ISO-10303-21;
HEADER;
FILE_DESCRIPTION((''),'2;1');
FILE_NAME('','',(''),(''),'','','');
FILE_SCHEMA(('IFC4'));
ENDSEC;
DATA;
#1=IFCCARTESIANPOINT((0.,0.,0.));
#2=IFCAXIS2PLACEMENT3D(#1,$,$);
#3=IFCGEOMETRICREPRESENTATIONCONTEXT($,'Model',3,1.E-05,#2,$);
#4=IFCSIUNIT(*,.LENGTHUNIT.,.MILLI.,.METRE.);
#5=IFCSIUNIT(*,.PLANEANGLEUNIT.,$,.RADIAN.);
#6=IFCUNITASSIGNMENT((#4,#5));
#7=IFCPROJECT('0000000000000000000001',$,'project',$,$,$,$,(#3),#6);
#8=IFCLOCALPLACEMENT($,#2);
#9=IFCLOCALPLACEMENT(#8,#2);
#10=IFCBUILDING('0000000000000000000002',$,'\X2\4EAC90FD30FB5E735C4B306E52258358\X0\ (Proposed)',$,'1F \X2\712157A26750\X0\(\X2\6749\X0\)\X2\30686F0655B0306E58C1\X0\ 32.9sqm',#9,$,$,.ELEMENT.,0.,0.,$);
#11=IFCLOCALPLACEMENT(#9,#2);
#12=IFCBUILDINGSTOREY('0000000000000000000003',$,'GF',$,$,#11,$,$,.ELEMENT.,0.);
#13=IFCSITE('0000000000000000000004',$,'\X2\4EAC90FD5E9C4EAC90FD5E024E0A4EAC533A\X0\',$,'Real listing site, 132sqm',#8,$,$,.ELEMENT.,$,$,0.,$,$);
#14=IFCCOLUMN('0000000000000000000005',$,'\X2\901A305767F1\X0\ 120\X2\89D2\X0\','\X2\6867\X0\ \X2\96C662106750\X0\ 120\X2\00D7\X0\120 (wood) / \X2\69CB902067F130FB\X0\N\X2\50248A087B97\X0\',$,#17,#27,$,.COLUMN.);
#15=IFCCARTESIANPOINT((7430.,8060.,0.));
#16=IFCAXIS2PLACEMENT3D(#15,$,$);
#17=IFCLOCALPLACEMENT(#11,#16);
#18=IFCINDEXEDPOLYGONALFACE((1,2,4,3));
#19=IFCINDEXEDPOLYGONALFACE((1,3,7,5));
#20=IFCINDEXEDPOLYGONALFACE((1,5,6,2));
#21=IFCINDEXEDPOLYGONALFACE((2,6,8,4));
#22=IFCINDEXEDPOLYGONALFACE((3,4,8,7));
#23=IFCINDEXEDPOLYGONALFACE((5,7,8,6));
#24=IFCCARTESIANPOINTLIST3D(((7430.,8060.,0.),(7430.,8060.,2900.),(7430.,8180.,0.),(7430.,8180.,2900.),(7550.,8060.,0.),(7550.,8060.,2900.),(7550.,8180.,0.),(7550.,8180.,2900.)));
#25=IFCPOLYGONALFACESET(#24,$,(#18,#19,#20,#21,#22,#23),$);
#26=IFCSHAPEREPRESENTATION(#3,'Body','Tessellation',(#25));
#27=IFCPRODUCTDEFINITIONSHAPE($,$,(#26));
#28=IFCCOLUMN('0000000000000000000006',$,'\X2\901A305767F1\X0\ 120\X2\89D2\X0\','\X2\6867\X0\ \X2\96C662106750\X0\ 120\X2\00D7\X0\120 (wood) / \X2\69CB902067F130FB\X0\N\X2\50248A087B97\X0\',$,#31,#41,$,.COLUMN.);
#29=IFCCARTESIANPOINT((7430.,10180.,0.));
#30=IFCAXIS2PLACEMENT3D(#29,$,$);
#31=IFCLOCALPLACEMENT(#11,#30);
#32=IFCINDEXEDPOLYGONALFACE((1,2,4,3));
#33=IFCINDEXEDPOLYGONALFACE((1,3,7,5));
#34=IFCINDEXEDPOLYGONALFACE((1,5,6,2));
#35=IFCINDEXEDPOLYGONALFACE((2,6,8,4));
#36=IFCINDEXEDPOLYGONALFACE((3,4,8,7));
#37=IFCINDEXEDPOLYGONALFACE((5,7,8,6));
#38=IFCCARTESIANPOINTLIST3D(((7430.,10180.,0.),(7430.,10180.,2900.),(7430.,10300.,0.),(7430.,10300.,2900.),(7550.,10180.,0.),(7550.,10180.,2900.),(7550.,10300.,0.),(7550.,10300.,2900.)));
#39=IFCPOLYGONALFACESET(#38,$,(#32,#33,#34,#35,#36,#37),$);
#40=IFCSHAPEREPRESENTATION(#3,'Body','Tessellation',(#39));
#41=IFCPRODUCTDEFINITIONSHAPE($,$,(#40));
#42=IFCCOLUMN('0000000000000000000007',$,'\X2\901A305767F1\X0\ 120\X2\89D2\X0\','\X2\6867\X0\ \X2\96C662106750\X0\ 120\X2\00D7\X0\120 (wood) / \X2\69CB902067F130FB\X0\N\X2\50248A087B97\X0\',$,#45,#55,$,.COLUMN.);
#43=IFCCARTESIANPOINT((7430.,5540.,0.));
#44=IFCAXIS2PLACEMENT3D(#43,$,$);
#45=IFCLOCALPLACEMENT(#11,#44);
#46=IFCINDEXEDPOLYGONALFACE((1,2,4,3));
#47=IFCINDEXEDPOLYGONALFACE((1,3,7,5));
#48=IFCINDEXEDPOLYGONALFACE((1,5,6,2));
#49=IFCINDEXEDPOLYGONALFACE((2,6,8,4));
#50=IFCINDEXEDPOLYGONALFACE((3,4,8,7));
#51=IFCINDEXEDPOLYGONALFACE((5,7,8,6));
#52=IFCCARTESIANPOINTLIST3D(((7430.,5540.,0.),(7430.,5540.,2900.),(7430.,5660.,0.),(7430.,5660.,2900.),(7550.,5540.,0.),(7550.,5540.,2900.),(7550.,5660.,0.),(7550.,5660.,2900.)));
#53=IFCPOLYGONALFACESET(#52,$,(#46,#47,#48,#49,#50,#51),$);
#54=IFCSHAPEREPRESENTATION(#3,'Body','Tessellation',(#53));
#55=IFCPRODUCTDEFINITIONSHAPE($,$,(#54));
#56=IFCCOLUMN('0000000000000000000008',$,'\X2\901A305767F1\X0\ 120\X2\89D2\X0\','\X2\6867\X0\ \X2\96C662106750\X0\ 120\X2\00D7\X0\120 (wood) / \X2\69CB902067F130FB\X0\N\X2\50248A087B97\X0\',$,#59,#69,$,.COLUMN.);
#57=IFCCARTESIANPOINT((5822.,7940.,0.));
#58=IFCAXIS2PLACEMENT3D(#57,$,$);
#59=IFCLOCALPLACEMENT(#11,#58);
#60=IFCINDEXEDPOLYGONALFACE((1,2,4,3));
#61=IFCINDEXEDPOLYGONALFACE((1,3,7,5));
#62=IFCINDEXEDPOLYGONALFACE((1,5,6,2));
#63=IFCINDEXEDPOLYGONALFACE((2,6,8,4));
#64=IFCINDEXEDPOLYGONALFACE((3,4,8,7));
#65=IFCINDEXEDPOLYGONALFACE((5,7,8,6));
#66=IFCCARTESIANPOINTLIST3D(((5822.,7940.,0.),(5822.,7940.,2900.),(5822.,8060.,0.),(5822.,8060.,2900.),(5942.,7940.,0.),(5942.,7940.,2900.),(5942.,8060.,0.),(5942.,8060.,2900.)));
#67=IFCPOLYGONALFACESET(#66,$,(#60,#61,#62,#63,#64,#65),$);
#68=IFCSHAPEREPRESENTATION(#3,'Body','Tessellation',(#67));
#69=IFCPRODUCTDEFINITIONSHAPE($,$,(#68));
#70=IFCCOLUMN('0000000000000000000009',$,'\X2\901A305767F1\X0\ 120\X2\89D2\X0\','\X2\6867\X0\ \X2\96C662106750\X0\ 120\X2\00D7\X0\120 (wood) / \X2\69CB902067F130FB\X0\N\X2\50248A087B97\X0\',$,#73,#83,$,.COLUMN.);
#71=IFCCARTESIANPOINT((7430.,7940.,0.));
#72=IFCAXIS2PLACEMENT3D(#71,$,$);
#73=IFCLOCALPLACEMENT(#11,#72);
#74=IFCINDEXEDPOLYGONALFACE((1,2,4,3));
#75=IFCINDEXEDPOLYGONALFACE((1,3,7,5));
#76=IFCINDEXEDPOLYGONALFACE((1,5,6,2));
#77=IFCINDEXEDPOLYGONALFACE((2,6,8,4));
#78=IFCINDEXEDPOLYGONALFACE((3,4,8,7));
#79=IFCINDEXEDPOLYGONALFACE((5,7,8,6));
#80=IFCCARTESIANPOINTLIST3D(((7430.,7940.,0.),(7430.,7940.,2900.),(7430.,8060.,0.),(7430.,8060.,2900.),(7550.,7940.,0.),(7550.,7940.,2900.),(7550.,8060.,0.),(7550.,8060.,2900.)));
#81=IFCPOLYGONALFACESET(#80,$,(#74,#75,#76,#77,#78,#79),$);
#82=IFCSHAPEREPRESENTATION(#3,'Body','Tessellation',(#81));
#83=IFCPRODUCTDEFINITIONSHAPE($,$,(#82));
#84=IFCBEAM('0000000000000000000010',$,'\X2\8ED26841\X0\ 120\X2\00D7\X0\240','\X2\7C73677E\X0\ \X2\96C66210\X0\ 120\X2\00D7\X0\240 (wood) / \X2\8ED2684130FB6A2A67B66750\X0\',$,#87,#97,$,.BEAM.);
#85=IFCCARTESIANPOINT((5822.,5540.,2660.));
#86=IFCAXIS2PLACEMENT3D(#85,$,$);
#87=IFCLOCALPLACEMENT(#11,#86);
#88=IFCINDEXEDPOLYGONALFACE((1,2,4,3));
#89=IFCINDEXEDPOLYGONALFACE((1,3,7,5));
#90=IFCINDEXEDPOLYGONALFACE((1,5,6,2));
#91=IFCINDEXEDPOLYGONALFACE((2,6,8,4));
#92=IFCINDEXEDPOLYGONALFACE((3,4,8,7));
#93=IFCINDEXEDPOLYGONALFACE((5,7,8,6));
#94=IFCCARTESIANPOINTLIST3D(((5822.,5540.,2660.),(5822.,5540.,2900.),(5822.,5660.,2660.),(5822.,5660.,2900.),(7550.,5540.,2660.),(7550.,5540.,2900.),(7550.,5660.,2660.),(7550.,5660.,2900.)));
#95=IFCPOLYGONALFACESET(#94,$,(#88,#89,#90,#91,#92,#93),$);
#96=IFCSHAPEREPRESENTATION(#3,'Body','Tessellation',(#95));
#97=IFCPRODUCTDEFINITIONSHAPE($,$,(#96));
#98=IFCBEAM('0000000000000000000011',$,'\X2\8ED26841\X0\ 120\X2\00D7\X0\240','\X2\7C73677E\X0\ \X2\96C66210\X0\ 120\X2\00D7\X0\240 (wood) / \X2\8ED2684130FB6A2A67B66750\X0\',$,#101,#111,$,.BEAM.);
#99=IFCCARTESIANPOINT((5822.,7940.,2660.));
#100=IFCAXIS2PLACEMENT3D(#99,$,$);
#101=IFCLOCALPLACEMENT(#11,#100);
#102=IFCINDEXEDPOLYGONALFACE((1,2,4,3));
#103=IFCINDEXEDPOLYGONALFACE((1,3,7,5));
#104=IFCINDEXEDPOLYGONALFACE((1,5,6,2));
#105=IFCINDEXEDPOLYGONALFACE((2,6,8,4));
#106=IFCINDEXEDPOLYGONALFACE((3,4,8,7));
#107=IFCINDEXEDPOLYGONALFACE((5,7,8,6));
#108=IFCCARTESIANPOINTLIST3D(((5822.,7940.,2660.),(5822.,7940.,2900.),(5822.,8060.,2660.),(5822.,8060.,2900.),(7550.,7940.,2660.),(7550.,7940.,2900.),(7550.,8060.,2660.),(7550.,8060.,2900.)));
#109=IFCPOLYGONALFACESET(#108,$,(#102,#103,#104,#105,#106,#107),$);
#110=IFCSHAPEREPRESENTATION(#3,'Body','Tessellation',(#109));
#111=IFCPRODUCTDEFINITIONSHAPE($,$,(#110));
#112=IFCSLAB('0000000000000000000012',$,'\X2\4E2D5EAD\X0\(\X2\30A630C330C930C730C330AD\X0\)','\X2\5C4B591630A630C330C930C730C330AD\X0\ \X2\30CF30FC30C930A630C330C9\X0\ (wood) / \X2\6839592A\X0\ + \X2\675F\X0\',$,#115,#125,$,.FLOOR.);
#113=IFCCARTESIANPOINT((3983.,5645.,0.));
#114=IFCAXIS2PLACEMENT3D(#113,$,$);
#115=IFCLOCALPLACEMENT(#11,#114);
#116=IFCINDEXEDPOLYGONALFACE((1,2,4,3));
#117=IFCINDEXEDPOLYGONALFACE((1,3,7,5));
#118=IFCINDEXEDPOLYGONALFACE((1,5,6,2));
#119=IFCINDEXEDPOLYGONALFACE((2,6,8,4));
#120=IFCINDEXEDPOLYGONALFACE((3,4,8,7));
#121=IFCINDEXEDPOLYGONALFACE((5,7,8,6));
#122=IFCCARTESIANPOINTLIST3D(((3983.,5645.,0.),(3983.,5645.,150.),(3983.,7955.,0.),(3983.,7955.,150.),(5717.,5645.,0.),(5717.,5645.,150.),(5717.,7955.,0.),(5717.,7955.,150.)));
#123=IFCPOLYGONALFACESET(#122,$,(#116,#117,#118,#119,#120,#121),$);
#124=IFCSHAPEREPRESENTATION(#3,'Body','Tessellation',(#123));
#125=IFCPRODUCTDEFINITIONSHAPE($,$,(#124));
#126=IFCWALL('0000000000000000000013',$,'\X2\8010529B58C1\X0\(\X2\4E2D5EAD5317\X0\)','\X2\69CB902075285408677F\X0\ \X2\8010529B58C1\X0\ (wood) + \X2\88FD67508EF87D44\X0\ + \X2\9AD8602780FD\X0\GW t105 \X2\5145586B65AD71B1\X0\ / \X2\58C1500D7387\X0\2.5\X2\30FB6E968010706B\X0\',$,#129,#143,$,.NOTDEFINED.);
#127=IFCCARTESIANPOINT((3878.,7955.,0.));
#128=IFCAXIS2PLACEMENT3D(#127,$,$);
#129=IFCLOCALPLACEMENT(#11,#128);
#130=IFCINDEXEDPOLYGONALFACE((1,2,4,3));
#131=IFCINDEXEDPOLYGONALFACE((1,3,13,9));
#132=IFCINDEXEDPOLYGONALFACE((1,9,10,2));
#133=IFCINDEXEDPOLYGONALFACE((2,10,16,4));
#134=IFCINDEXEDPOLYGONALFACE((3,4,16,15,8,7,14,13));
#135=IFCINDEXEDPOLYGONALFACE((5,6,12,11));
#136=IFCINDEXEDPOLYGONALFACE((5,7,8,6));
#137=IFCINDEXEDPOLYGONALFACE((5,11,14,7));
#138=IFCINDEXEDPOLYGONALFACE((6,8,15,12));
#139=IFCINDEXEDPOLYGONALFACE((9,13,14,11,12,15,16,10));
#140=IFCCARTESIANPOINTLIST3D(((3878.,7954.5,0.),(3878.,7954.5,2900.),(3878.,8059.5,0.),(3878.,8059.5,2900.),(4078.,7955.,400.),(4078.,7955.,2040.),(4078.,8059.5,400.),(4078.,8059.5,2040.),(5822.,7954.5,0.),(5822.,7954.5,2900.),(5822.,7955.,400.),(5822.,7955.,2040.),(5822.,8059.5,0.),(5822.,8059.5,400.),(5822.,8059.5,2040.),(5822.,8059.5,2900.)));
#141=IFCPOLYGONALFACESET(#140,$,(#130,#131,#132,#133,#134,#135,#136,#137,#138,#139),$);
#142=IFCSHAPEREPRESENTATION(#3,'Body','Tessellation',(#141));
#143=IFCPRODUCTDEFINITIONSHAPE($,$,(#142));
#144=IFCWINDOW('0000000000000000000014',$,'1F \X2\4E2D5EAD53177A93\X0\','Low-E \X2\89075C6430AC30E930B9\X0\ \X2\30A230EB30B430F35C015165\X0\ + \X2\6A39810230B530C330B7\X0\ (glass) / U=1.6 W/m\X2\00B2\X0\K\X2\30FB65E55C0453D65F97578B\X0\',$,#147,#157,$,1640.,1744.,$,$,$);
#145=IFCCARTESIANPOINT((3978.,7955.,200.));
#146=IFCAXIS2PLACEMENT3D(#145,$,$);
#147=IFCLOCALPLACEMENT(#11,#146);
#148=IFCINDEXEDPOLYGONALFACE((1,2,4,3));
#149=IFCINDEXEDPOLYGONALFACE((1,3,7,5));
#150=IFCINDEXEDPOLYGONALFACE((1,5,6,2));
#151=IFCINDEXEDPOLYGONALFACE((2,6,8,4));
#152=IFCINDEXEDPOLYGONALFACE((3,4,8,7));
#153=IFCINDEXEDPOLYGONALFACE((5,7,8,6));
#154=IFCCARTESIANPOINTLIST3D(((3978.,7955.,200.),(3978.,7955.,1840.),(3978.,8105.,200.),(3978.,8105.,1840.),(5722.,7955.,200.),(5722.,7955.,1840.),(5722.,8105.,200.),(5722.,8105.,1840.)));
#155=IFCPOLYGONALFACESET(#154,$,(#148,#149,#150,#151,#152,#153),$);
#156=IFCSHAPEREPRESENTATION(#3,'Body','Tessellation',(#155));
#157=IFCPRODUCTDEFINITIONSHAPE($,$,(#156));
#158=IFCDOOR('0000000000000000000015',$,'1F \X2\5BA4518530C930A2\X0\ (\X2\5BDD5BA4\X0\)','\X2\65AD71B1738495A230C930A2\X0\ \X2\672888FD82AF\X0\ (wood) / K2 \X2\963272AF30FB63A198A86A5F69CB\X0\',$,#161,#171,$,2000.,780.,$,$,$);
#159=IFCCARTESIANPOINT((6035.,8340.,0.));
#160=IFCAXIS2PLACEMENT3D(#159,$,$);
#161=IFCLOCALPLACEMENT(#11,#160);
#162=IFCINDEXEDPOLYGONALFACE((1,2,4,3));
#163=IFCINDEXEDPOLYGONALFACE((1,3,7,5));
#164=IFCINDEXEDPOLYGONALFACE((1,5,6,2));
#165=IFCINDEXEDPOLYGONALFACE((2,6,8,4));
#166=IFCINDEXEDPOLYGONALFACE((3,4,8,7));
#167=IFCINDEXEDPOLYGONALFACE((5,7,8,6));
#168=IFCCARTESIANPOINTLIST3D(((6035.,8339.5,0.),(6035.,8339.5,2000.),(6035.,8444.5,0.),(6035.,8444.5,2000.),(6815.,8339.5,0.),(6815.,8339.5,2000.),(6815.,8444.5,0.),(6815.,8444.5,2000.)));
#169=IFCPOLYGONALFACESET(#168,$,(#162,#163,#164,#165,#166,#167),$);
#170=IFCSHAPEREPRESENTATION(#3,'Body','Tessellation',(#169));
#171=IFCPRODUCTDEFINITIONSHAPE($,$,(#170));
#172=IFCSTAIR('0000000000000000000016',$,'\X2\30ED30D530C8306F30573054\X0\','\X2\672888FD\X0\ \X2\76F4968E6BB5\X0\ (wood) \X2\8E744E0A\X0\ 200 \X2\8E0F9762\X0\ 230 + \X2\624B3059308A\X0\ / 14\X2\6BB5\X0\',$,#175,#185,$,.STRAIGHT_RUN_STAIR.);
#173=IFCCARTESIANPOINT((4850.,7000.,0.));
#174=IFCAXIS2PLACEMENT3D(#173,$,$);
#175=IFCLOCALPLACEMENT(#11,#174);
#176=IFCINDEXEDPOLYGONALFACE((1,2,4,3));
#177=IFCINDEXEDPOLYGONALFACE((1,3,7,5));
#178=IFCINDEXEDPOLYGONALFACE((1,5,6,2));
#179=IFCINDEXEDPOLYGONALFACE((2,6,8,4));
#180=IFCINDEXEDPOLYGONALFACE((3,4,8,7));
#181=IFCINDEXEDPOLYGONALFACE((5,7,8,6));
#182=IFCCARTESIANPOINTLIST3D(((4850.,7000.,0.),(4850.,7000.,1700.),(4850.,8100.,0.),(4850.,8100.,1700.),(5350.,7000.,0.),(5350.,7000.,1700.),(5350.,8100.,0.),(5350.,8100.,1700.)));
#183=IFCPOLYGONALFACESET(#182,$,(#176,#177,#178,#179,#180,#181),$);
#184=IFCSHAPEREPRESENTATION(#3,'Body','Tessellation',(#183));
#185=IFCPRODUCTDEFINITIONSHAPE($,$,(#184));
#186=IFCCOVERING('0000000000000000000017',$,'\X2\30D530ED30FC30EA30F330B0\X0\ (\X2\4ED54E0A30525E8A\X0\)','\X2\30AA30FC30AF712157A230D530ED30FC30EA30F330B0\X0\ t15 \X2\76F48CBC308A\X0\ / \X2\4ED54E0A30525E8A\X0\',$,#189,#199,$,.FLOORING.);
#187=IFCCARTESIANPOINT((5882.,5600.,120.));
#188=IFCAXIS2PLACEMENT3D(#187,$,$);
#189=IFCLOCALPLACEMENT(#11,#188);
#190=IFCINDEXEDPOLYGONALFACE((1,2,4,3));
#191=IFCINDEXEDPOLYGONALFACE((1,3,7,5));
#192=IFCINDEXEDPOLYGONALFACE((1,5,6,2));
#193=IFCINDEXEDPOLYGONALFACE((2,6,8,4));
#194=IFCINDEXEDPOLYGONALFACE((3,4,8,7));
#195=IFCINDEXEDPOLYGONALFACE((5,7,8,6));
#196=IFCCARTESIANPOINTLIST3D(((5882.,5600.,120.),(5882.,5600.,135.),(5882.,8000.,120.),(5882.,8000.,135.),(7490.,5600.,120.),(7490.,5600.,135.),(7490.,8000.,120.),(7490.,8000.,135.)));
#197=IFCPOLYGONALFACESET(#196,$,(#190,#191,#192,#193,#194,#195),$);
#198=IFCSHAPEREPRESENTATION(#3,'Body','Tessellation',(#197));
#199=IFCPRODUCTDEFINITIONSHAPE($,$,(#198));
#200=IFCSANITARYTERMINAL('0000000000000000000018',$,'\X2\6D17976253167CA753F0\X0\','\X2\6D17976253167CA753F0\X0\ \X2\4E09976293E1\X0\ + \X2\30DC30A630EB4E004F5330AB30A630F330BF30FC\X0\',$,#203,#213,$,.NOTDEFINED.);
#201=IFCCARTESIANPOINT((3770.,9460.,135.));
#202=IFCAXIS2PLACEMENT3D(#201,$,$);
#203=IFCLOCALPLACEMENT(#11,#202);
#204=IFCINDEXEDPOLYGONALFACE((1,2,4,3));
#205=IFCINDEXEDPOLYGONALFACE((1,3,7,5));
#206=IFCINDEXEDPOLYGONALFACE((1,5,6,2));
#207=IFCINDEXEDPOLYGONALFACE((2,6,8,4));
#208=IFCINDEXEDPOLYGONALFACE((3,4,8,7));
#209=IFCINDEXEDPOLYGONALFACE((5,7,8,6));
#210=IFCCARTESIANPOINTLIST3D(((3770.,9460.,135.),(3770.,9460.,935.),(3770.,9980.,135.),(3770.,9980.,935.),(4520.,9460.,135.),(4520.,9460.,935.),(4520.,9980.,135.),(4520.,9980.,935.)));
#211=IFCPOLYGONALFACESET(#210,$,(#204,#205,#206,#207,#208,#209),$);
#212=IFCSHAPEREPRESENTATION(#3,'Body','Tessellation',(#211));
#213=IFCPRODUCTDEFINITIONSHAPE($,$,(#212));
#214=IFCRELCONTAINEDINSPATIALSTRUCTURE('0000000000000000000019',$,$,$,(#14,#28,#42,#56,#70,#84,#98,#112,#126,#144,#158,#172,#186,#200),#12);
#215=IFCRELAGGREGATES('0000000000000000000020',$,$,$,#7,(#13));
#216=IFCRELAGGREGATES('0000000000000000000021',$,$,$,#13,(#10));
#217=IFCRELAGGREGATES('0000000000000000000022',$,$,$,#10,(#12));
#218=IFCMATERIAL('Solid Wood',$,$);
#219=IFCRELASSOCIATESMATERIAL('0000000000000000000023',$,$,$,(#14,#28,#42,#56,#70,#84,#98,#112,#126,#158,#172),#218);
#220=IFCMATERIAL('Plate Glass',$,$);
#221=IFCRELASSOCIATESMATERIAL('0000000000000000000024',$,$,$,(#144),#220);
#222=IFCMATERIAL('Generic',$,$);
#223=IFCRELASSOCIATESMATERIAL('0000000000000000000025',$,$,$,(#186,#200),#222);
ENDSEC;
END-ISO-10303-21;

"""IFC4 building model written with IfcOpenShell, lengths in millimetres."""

from ifc_helpers import new_model, si_unit, frame, frame_2d, origin, place, context, project, spatial, rectangle, extrude, material, element, fill, save


model = new_model("IFC4")

# Units and contexts
model_context = context("Model", 3, precision=1e-05, world=origin())
ifc_project = project(units=[si_unit("LENGTHUNIT", "METRE", prefix="MILLI"), si_unit("PLANEANGLEUNIT", "RADIAN")], contexts=[model_context])

# Site, building, storey
site_placement = place(None, origin())
site = spatial("IfcSite", under=ifc_project, at=site_placement, Name="京都府京都市上京区", ObjectType="Real listing site, 132sqm", CompositionType="ELEMENT", RefElevation=0.0)
building_placement = place(site_placement, origin())
building = spatial("IfcBuilding", under=site, at=building_placement, Name="京都・平屋の別荘 (Proposed)", ObjectType="1F 無垢材(杉)と漆喰の壁 32.9sqm", CompositionType="ELEMENT", ElevationOfRefHeight=0.0, ElevationOfTerrain=0.0)
storey_placement = place(building_placement, origin())
storey = spatial("IfcBuildingStorey", under=building, at=storey_placement, Name="GF", CompositionType="ELEMENT", Elevation=0.0)

# Columns
ifc_material_1 = material(Name="Solid Wood")
column_1_placement = place(storey_placement, frame((7430.0, 8060.0, 0.0)))
element("IfcColumn", 1, at=column_1_placement, inside=storey, material=ifc_material_1, Name="通し柱 120角", Description="桧 集成材 120×120 (wood) / 構造柱・N値計算", PredefinedType="COLUMN", context=model_context, shape_type="SweptSolid", body=[
    extrude(rectangle(XDim=120.0, YDim=120.0, at=frame_2d((60.0, 60.0))), frame((7430.0, 8060.0, 0.0)), (0.0, 0.0, 1.0), 2900.0),
])
column_2_placement = place(storey_placement, frame((7430.0, 10180.0, 0.0)))
element("IfcColumn", 2, at=column_2_placement, inside=storey, material=ifc_material_1, Name="通し柱 120角", Description="桧 集成材 120×120 (wood) / 構造柱・N値計算", PredefinedType="COLUMN", context=model_context, shape_type="SweptSolid", body=[
    extrude(rectangle(XDim=120.0, YDim=120.0, at=frame_2d((60.0, 60.0))), frame((7430.0, 10180.0, 0.0)), (0.0, 0.0, 1.0), 2900.0),
])
column_3_placement = place(storey_placement, frame((7430.0, 5540.0, 0.0)))
element("IfcColumn", 3, at=column_3_placement, inside=storey, material=ifc_material_1, Name="通し柱 120角", Description="桧 集成材 120×120 (wood) / 構造柱・N値計算", PredefinedType="COLUMN", context=model_context, shape_type="SweptSolid", body=[
    extrude(rectangle(XDim=120.0, YDim=120.0, at=frame_2d((60.0, 60.0))), frame((7430.0, 5540.0, 0.0)), (0.0, 0.0, 1.0), 2900.0),
])
column_4_placement = place(storey_placement, frame((5822.0, 7940.0, 0.0)))
element("IfcColumn", 4, at=column_4_placement, inside=storey, material=ifc_material_1, Name="通し柱 120角", Description="桧 集成材 120×120 (wood) / 構造柱・N値計算", PredefinedType="COLUMN", context=model_context, shape_type="SweptSolid", body=[
    extrude(rectangle(XDim=120.0, YDim=120.0, at=frame_2d((60.0, 60.0))), frame((5822.0, 7940.0, 0.0)), (0.0, 0.0, 1.0), 2900.0),
])
column_5_placement = place(storey_placement, frame((7430.0, 7940.0, 0.0)))
element("IfcColumn", 5, at=column_5_placement, inside=storey, material=ifc_material_1, Name="通し柱 120角", Description="桧 集成材 120×120 (wood) / 構造柱・N値計算", PredefinedType="COLUMN", context=model_context, shape_type="SweptSolid", body=[
    extrude(rectangle(XDim=120.0, YDim=120.0, at=frame_2d((60.0, 60.0))), frame((7430.0, 7940.0, 0.0)), (0.0, 0.0, 1.0), 2900.0),
])

# Beams
beam_1_placement = place(storey_placement, frame((5822.0, 5540.0, 2660.0)))
element("IfcBeam", 6, at=beam_1_placement, inside=storey, material=ifc_material_1, Name="軒桁 120×240", Description="米松 集成 120×240 (wood) / 軒桁・横架材", PredefinedType="BEAM", context=model_context, shape_type="SweptSolid", body=[
    extrude(rectangle(XDim=1728.0, YDim=120.0, at=frame_2d((864.0, 60.0))), frame((5822.0, 5540.0, 2660.0)), (0.0, 0.0, 1.0), 240.0),
])
beam_2_placement = place(storey_placement, frame((5822.0, 7940.0, 2660.0)))
element("IfcBeam", 7, at=beam_2_placement, inside=storey, material=ifc_material_1, Name="軒桁 120×240", Description="米松 集成 120×240 (wood) / 軒桁・横架材", PredefinedType="BEAM", context=model_context, shape_type="SweptSolid", body=[
    extrude(rectangle(XDim=1728.0, YDim=120.0, at=frame_2d((864.0, 60.0))), frame((5822.0, 7940.0, 2660.0)), (0.0, 0.0, 1.0), 240.0),
])

# Slab
slab_placement = place(storey_placement, frame((3983.0, 5645.0, 0.0)))
element("IfcSlab", 8, at=slab_placement, inside=storey, material=ifc_material_1, Name="中庭(ウッドデッキ)", Description="屋外ウッドデッキ ハードウッド (wood) / 根太 + 束", PredefinedType="FLOOR", context=model_context, shape_type="SweptSolid", body=[
    extrude(rectangle(XDim=1734.0, YDim=2310.0, at=frame_2d((867.0, 1155.0))), frame((3983.0, 5645.0, 0.0)), (0.0, 0.0, 1.0), 150.0),
])

# Wall, opening, window
wall_1_placement = place(storey_placement, frame((3878.0, 7955.0, 0.0)))
wall_1 = element("IfcWall", 9, at=wall_1_placement, inside=storey, material=ifc_material_1, Name="耐力壁(中庭北)", Description="構造用合板 耐力壁 (wood) + 製材軸組 + 高性能GW t105 充填断熱 / 壁倍率2.5・準耐火", PredefinedType="NOTDEFINED", context=model_context, shape_type="SweptSolid", body=[
    extrude(rectangle(XDim=1944.0, YDim=105.0, at=frame_2d((972.0, 52.0))), frame((3878.0, 7955.0, 0.0)), (0.0, 0.0, 1.0), 2900.0),
])
opening_placement = place(storey_placement, frame((3978.0, 7955.0, 200.0)))
opening = element("IfcOpeningElement", 10, at=opening_placement, cuts=wall_1, PredefinedType="NOTDEFINED", context=model_context, shape_type="SweptSolid", body=[
    extrude(rectangle(XDim=1744.0, YDim=150.0, at=frame_2d((872.0, 75.0))), frame((3978.0, 7955.0, 200.0)), (0.0, 0.0, 1.0), 1640.0),
])
ifc_material_2 = material(Name="Plate Glass")
window_placement = place(storey_placement, frame((3978.0, 7955.0, 200.0)))
window = element("IfcWindow", 11, at=window_placement, inside=storey, material=ifc_material_2, Name="1F 中庭北窓", Description="Low-E 複層ガラス アルゴン封入 + 樹脂サッシ (glass) / U=1.6 W/m²K・日射取得型", OverallHeight=1640.0, OverallWidth=1744.0, context=model_context, shape_type="SweptSolid", body=[
    extrude(rectangle(XDim=1744.0, YDim=150.0, at=frame_2d((872.0, 75.0))), frame((3978.0, 7955.0, 200.0)), (0.0, 0.0, 1.0), 1640.0),
])
fill(opening, window)

# Door
door_placement = place(storey_placement, frame((6035.0, 8340.0, 0.0)))
element("IfcDoor", 12, at=door_placement, inside=storey, material=ifc_material_1, Name="1F 室内ドア (寝室)", Description="断熱玄関ドア 木製芯 (wood) / K2 防犯・採風機構", OverallHeight=2000.0, OverallWidth=780.0, context=model_context, shape_type="SweptSolid", body=[
    extrude(rectangle(XDim=780.0, YDim=105.0, at=frame_2d((390.0, 52.0))), frame((6035.0, 8340.0, 0.0)), (0.0, 0.0, 1.0), 2000.0),
])

# Stair
stair_placement = place(storey_placement, frame((4850.0, 7000.0, 0.0)))
element("IfcStair", 13, at=stair_placement, inside=storey, material=ifc_material_1, Name="ロフトはしご", Description="木製 直階段 (wood) 蹴上 200 踏面 230 + 手すり / 14段", PredefinedType="STRAIGHT_RUN_STAIR", context=model_context, shape_type="SweptSolid", body=[
    extrude(rectangle(XDim=500.0, YDim=1100.0, at=frame_2d((250.0, 550.0))), frame((4850.0, 7000.0, 0.0)), (0.0, 0.0, 1.0), 1700.0),
])

# Covering
ifc_material_3 = material(Name="Generic")
covering_placement = place(storey_placement, frame((5882.0, 5600.0, 120.0)))
element("IfcCovering", 14, at=covering_placement, inside=storey, material=ifc_material_3, Name="フローリング (仕上げ床)", Description="オーク無垢フローリング t15 直貼り / 仕上げ床", PredefinedType="FLOORING", context=model_context, shape_type="SweptSolid", body=[
    extrude(rectangle(XDim=1608.0, YDim=2400.0, at=frame_2d((804.0, 1200.0))), frame((5882.0, 5600.0, 120.0)), (0.0, 0.0, 1.0), 15.0),
])

# Sanitary terminal
sanitary_terminal_1_placement = place(storey_placement, frame((3770.0, 9460.0, 135.0)))
element("IfcSanitaryTerminal", 15, at=sanitary_terminal_1_placement, inside=storey, material=ifc_material_3, Name="洗面化粧台", Description="洗面化粧台 三面鏡 + ボウル一体カウンター", PredefinedType="NOTDEFINED", context=model_context, shape_type="SweptSolid", body=[
    extrude(rectangle(XDim=750.0, YDim=520.0, at=frame_2d((375.0, 260.0))), frame((3770.0, 9460.0, 135.0)), (0.0, 0.0, 1.0), 800.0),
])

save(model, "model.ifc")
